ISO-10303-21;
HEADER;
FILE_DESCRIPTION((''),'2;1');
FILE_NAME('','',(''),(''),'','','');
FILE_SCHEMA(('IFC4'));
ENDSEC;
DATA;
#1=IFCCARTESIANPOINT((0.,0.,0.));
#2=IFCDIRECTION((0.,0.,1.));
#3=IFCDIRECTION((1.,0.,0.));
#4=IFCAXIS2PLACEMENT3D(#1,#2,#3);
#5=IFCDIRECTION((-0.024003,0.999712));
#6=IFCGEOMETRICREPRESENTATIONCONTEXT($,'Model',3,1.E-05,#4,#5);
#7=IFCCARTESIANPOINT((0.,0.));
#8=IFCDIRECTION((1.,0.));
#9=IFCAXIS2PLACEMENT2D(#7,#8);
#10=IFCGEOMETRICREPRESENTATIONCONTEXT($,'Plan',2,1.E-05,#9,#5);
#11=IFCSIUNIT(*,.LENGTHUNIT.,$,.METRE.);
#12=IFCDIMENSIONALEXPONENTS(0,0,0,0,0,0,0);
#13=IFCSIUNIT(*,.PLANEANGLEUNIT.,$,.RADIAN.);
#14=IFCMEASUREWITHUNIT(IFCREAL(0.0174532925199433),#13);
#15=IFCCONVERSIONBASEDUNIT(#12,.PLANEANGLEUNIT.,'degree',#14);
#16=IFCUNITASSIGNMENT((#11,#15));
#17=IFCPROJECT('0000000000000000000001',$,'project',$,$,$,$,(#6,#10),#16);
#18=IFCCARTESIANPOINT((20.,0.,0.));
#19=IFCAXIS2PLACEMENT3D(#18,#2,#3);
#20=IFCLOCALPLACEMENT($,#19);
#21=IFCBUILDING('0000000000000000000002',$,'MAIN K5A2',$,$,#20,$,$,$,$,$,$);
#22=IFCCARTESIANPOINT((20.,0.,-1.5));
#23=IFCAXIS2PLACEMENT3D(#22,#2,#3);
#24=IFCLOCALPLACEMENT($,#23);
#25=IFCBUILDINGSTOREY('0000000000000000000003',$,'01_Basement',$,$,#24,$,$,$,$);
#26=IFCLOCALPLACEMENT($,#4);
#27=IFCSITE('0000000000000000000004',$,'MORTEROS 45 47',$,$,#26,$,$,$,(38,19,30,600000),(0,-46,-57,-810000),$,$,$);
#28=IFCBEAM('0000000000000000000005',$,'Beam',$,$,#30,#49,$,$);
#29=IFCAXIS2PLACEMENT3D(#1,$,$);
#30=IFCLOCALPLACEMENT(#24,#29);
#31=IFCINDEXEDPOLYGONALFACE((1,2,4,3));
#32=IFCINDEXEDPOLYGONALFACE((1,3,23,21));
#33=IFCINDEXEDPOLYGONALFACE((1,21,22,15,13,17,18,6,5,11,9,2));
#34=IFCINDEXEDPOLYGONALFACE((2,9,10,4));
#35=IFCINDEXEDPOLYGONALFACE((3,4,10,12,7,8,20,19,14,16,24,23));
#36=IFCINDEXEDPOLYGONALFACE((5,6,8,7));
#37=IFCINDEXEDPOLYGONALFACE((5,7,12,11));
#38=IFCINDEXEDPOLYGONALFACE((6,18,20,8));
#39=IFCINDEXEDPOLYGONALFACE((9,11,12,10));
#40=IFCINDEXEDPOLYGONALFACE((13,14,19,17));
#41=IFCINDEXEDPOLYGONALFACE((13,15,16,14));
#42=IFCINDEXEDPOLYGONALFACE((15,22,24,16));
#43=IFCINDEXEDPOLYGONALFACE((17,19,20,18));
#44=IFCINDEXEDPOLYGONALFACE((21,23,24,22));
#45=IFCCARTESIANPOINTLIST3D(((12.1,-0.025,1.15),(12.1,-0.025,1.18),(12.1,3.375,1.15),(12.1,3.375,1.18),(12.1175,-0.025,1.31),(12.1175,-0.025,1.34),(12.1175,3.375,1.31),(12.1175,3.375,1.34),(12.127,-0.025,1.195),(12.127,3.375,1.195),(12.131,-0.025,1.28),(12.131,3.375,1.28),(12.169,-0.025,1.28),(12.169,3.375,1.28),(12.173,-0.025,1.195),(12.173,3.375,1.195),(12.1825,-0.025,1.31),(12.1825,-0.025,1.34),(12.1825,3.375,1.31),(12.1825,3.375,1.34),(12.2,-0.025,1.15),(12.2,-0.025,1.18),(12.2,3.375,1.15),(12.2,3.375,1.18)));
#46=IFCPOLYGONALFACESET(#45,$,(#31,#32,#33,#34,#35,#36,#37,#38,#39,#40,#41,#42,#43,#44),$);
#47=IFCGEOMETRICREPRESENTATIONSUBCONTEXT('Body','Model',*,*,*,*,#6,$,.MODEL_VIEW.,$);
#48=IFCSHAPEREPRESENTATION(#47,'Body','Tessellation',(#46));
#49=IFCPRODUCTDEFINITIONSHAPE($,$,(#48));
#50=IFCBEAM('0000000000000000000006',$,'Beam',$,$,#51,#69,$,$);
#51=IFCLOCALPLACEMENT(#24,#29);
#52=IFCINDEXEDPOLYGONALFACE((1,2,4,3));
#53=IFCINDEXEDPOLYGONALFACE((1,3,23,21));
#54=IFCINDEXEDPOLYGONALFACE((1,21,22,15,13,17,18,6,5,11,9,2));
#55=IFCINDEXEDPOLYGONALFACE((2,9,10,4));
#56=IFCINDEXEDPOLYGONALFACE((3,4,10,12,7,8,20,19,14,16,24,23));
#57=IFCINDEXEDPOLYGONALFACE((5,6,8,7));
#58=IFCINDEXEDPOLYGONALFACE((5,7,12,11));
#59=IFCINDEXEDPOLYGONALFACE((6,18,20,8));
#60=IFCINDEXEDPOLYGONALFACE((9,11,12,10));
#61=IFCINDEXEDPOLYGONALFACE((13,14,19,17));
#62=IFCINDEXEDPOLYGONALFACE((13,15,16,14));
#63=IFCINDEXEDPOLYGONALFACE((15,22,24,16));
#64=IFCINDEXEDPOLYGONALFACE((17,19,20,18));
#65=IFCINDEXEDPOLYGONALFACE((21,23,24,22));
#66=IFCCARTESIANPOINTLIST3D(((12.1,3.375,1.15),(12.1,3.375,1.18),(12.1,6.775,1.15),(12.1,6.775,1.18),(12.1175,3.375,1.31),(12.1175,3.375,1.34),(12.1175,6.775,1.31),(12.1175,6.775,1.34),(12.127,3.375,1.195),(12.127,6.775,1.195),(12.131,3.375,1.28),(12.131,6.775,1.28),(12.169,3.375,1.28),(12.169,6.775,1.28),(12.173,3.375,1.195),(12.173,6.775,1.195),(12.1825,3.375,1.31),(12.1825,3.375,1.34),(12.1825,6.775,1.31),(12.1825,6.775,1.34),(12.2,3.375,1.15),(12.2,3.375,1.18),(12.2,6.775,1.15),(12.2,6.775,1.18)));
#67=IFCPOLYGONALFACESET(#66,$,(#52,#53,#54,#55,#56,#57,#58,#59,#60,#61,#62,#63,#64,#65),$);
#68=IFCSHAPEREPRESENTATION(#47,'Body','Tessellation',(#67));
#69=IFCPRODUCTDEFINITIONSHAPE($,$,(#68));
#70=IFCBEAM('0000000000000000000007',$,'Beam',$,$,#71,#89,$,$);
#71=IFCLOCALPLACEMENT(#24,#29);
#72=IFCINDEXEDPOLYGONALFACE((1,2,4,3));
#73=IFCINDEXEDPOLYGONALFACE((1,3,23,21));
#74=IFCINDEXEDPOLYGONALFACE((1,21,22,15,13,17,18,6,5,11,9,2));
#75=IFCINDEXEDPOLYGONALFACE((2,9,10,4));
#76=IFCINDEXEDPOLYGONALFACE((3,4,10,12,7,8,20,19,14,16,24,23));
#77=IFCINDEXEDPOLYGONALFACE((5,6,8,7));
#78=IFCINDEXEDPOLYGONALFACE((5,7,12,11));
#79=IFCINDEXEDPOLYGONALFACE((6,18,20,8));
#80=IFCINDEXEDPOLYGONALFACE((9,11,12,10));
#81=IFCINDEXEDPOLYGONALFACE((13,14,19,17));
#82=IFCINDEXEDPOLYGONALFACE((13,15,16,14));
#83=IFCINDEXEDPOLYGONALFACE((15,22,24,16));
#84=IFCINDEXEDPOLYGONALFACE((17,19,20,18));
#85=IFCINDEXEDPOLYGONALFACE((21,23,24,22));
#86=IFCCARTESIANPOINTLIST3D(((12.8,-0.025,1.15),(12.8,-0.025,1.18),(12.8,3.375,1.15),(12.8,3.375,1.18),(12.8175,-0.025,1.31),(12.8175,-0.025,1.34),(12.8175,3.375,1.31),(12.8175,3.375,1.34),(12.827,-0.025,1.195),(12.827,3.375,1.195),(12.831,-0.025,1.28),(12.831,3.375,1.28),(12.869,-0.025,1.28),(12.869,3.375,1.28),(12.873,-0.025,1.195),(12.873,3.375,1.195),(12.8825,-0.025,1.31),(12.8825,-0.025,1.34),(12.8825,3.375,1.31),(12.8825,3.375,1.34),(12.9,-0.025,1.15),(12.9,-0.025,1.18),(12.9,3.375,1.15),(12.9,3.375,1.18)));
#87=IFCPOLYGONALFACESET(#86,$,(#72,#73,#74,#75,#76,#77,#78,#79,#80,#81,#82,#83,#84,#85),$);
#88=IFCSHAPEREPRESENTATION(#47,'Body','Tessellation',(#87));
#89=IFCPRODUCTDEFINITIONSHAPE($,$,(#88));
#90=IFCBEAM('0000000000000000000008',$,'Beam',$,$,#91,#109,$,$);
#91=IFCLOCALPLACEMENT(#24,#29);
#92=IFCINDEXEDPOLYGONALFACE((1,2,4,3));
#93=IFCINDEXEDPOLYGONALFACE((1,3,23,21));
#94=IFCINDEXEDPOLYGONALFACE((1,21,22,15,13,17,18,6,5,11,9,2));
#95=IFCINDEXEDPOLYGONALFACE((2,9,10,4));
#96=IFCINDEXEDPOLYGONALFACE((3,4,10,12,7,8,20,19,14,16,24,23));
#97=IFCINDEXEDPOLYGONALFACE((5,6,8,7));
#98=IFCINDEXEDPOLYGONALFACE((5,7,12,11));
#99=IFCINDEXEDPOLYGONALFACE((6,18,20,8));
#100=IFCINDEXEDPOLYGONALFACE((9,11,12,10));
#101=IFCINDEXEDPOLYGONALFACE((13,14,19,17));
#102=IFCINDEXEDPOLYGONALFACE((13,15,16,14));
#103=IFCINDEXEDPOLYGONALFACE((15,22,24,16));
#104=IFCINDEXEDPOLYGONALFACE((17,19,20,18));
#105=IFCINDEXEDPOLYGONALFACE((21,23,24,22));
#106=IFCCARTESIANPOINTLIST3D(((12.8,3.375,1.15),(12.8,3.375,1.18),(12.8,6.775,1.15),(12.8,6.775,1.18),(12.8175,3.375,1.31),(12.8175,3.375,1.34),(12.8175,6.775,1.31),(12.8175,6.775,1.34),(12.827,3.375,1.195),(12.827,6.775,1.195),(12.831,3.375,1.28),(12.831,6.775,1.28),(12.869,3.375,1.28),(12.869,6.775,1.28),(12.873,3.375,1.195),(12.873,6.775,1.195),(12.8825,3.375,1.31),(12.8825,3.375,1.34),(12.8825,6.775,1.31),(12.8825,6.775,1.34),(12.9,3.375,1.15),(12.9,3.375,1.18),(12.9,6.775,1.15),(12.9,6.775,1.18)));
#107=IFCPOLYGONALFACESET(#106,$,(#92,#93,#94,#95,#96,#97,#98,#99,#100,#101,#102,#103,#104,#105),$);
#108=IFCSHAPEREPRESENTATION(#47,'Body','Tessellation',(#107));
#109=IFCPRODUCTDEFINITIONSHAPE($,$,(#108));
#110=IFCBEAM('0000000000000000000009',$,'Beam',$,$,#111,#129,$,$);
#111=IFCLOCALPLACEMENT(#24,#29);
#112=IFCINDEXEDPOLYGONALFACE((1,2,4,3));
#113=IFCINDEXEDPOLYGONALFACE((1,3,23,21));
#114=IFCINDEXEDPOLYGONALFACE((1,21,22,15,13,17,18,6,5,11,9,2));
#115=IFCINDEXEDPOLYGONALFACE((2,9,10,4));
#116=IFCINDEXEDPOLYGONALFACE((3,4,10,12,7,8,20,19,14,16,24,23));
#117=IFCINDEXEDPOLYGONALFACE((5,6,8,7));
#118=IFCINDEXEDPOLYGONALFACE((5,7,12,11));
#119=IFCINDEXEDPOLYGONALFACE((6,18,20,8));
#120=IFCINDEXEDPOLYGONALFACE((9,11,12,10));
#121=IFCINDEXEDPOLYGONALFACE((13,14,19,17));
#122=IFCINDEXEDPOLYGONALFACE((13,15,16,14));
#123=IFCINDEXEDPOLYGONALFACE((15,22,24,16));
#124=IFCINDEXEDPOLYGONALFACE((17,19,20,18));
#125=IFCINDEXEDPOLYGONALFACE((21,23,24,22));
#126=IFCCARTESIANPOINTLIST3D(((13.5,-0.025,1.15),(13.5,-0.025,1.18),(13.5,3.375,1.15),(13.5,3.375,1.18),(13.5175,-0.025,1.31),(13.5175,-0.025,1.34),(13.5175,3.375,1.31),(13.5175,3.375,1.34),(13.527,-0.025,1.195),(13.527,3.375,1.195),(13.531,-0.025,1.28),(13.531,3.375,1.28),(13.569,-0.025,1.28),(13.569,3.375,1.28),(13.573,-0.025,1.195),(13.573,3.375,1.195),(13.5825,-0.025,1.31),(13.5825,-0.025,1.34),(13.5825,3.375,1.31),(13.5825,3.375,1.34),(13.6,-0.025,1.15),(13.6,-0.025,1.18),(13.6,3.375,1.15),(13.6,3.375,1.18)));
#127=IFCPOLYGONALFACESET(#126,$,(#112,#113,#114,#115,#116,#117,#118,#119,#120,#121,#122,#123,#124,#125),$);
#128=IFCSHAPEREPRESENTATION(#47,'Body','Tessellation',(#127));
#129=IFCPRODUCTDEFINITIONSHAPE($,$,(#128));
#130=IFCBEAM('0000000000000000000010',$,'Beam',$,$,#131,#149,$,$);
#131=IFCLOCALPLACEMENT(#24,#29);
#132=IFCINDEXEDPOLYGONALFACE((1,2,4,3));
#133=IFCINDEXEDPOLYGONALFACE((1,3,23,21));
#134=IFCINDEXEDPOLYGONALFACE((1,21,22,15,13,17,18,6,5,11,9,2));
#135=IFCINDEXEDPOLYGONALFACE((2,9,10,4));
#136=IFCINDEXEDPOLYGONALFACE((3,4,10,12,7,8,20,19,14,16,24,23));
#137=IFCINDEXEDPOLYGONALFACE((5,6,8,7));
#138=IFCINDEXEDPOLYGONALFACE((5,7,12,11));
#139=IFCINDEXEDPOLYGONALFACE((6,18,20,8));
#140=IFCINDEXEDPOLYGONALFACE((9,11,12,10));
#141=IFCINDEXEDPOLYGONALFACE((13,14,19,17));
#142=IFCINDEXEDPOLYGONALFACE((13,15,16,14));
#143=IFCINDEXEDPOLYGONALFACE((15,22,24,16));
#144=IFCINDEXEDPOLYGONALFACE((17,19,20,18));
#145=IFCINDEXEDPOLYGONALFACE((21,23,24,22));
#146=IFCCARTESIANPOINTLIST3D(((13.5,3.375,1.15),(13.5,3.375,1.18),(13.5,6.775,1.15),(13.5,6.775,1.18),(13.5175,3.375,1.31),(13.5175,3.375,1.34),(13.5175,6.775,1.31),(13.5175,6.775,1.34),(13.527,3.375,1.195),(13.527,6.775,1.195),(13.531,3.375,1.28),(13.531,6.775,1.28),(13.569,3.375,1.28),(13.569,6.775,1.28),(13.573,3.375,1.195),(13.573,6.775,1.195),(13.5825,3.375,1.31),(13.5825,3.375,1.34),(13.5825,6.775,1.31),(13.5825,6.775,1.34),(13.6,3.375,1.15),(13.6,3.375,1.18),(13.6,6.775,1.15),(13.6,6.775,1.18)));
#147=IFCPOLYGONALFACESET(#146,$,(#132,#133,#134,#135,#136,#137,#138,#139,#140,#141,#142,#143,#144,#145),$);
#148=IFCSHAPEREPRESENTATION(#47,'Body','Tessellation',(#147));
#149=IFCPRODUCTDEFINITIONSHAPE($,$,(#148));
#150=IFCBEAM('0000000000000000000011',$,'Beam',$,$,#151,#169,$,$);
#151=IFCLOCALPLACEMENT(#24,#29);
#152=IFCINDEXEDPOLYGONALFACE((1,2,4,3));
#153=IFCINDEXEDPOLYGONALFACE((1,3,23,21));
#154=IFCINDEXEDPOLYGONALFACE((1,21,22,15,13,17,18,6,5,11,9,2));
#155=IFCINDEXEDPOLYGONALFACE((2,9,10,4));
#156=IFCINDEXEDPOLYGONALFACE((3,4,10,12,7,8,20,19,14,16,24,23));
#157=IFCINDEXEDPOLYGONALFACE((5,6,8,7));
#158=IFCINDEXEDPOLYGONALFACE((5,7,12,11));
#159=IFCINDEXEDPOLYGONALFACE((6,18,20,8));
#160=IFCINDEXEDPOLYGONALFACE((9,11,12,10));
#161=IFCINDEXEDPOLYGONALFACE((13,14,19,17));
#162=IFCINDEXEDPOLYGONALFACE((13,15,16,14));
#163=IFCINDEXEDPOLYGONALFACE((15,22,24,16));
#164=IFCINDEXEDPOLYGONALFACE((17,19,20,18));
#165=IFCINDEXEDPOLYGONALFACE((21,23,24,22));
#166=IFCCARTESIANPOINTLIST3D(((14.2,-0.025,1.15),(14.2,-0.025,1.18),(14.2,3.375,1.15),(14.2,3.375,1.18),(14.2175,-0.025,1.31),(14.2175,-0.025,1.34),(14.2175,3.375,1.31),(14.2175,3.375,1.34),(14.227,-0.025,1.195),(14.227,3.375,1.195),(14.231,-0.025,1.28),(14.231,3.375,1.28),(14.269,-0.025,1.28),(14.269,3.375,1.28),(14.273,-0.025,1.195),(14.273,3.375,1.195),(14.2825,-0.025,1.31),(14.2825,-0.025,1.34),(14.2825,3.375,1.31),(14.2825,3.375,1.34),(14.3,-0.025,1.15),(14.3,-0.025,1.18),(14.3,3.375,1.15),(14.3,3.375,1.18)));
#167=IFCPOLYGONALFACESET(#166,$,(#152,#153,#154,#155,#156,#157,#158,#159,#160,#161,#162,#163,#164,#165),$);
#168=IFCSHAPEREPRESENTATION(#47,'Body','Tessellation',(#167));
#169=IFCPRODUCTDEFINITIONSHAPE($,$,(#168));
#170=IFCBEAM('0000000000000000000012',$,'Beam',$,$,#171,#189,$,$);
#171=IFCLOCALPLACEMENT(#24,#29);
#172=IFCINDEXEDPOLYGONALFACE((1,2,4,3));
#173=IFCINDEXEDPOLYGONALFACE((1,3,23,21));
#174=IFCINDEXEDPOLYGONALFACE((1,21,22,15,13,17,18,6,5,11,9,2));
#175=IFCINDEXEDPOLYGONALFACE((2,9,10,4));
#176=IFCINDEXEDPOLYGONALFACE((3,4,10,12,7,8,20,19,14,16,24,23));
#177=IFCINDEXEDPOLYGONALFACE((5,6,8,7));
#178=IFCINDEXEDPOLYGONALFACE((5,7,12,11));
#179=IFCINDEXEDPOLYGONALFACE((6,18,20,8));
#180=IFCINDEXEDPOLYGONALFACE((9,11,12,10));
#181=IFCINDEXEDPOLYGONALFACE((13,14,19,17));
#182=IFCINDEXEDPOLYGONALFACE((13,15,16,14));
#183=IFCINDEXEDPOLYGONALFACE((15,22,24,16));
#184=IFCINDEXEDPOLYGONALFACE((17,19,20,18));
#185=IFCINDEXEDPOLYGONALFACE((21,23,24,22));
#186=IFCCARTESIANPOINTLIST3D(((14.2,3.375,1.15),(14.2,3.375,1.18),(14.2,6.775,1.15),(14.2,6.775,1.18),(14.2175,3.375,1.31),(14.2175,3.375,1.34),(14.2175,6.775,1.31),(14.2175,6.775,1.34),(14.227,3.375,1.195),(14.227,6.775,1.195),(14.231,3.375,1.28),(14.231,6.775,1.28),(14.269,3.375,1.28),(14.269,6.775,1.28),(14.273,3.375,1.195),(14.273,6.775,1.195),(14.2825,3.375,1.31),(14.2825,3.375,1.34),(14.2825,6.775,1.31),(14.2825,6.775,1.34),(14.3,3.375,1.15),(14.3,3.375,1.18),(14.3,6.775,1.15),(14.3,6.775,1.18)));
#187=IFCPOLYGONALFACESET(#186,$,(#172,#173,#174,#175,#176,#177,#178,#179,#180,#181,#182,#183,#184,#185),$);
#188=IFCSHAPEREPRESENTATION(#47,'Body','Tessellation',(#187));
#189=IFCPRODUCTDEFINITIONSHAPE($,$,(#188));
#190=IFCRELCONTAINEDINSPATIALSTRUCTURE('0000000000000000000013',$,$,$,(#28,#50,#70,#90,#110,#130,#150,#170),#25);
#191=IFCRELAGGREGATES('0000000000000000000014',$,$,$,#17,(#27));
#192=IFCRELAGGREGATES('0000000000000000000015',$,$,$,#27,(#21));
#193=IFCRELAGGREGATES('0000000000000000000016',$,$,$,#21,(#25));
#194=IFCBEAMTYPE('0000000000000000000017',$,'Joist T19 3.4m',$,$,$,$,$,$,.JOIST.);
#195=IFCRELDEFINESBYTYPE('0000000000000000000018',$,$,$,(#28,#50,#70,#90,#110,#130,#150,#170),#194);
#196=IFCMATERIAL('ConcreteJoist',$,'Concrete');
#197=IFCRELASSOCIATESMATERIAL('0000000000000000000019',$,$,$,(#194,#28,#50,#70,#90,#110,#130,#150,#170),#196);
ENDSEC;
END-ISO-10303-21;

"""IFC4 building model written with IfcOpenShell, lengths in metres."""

from ifc_helpers import new_model, entity, si_unit, converted_unit, direction, frame, origin_with_axes, origin_2d_with_axis, place, context, subcontext, project, spatial, indexed_curve, outline, extrude, material, material_profile, profile_set, profile_usage, type_object, element, save


model = new_model("IFC4")

# Units and contexts
model_context = context("Model", 3, precision=1e-05, world=origin_with_axes(), true_north=direction((-0.024003, 0.999712)))
plan_context = context("Plan", 2, precision=1e-05, world=origin_2d_with_axis(), true_north=direction((-0.024003, 0.999712)))
body_context = subcontext(model_context, "Body", "Model", "MODEL_VIEW")
ifc_project = project(units=[si_unit("LENGTHUNIT", "METRE"), converted_unit("PLANEANGLEUNIT", "degree", entity("IfcReal", 0.0174532925199433), si_unit("PLANEANGLEUNIT", "RADIAN"), dimensions=[0, 0, 0, 0, 0, 0, 0])], contexts=[model_context, plan_context])

# Site, building, storey
site_placement = place(None, origin_with_axes())
site = spatial("IfcSite", under=ifc_project, at=site_placement, Name="MORTEROS 45 47", RefLatitude=(38, 19, 30, 600000), RefLongitude=(0, -46, -57, -810000))
building_placement = place(None, frame((20.0, 0.0, 0.0), z_axis=(0.0, 0.0, 1.0), x_axis=(1.0, 0.0, 0.0)))
building = spatial("IfcBuilding", under=site, at=building_placement, Name="MAIN K5A2")
storey_placement = place(None, frame((20.0, 0.0, -1.5), z_axis=(0.0, 0.0, 1.0), x_axis=(1.0, 0.0, 0.0)))
storey = spatial("IfcBuildingStorey", under=building, at=storey_placement, Name="01_Basement")

# Beams
ifc_material = material(Name="ConcreteJoist", Category="Concrete")
ifc_material_profile = material_profile(ifc_material, outline(indexed_curve([(0.019, 0.13), (0.023, 0.045), (0.05, 0.03), (0.05, 0.0), (-0.05, 0.0), (-0.05, 0.03), (-0.023, 0.045), (-0.019, 0.13), (-0.0325, 0.16), (-0.0325, 0.19), (0.0325, 0.19), (0.0325, 0.16), (0.019, 0.13)])))
ifc_profile_set = profile_set([ifc_material_profile], Name="JoistMaterialProfileSet")
ifc_profile_usage_1 = profile_usage(ifc_profile_set, cardinal=5)
beam_type = type_object("IfcBeamType", Name="Joist T19 3.4m", PredefinedType="JOIST", material=ifc_profile_set)
beam_1_placement = place(None, frame((32.15, -0.025, -0.35), z_axis=(0.0, 1.0, 0.0), x_axis=(-1.0, 0.0, 0.0)))
element("IfcBeam", 1, at=beam_1_placement, inside=storey, type_object=beam_type, material=ifc_profile_usage_1, Name="Beam", context=body_context, shape_type="SweptSolid", body=[
    extrude(outline(indexed_curve([(0.019, 0.13), (0.023, 0.045), (0.05, 0.03), (0.05, 0.0), (-0.05, 0.0), (-0.05, 0.03), (-0.023, 0.045), (-0.019, 0.13), (-0.0325, 0.16), (-0.0325, 0.19), (0.0325, 0.19), (0.0325, 0.16), (0.019, 0.13)])), origin_with_axes(), (0.0, 0.0, 1.0), 3.4),
])
ifc_profile_usage_2 = profile_usage(ifc_profile_set, cardinal=5)
beam_2_placement = place(None, frame((32.15, 3.375, -0.35), z_axis=(0.0, 1.0, 0.0), x_axis=(-1.0, 0.0, 0.0)))
element("IfcBeam", 2, at=beam_2_placement, inside=storey, type_object=beam_type, material=ifc_profile_usage_2, Name="Beam", context=body_context, shape_type="SweptSolid", body=[
    extrude(outline(indexed_curve([(0.019, 0.13), (0.023, 0.045), (0.05, 0.03), (0.05, 0.0), (-0.05, 0.0), (-0.05, 0.03), (-0.023, 0.045), (-0.019, 0.13), (-0.0325, 0.16), (-0.0325, 0.19), (0.0325, 0.19), (0.0325, 0.16), (0.019, 0.13)])), origin_with_axes(), (0.0, 0.0, 1.0), 3.4),
])
ifc_profile_usage_3 = profile_usage(ifc_profile_set, cardinal=5)
beam_3_placement = place(None, frame((32.85, -0.025, -0.35), z_axis=(0.0, 1.0, 0.0), x_axis=(-1.0, 0.0, 0.0)))
element("IfcBeam", 3, at=beam_3_placement, inside=storey, type_object=beam_type, material=ifc_profile_usage_3, Name="Beam", context=body_context, shape_type="SweptSolid", body=[
    extrude(outline(indexed_curve([(0.019, 0.13), (0.023, 0.045), (0.05, 0.03), (0.05, 0.0), (-0.05, 0.0), (-0.05, 0.03), (-0.023, 0.045), (-0.019, 0.13), (-0.0325, 0.16), (-0.0325, 0.19), (0.0325, 0.19), (0.0325, 0.16), (0.019, 0.13)])), origin_with_axes(), (0.0, 0.0, 1.0), 3.4),
])
ifc_profile_usage_4 = profile_usage(ifc_profile_set, cardinal=5)
beam_4_placement = place(None, frame((32.85, 3.375, -0.35), z_axis=(0.0, 1.0, 0.0), x_axis=(-1.0, 0.0, 0.0)))
element("IfcBeam", 4, at=beam_4_placement, inside=storey, type_object=beam_type, material=ifc_profile_usage_4, Name="Beam", context=body_context, shape_type="SweptSolid", body=[
    extrude(outline(indexed_curve([(0.019, 0.13), (0.023, 0.045), (0.05, 0.03), (0.05, 0.0), (-0.05, 0.0), (-0.05, 0.03), (-0.023, 0.045), (-0.019, 0.13), (-0.0325, 0.16), (-0.0325, 0.19), (0.0325, 0.19), (0.0325, 0.16), (0.019, 0.13)])), origin_with_axes(), (0.0, 0.0, 1.0), 3.4),
])
ifc_profile_usage_5 = profile_usage(ifc_profile_set, cardinal=5)
beam_5_placement = place(None, frame((33.55, -0.025, -0.35), z_axis=(0.0, 1.0, 0.0), x_axis=(-1.0, 0.0, 0.0)))
element("IfcBeam", 5, at=beam_5_placement, inside=storey, type_object=beam_type, material=ifc_profile_usage_5, Name="Beam", context=body_context, shape_type="SweptSolid", body=[
    extrude(outline(indexed_curve([(0.019, 0.13), (0.023, 0.045), (0.05, 0.03), (0.05, 0.0), (-0.05, 0.0), (-0.05, 0.03), (-0.023, 0.045), (-0.019, 0.13), (-0.0325, 0.16), (-0.0325, 0.19), (0.0325, 0.19), (0.0325, 0.16), (0.019, 0.13)])), origin_with_axes(), (0.0, 0.0, 1.0), 3.4),
])
ifc_profile_usage_6 = profile_usage(ifc_profile_set, cardinal=5)
beam_6_placement = place(None, frame((33.55, 3.375, -0.35), z_axis=(0.0, 1.0, 0.0), x_axis=(-1.0, 0.0, 0.0)))
element("IfcBeam", 6, at=beam_6_placement, inside=storey, type_object=beam_type, material=ifc_profile_usage_6, Name="Beam", context=body_context, shape_type="SweptSolid", body=[
    extrude(outline(indexed_curve([(0.019, 0.13), (0.023, 0.045), (0.05, 0.03), (0.05, 0.0), (-0.05, 0.0), (-0.05, 0.03), (-0.023, 0.045), (-0.019, 0.13), (-0.0325, 0.16), (-0.0325, 0.19), (0.0325, 0.19), (0.0325, 0.16), (0.019, 0.13)])), origin_with_axes(), (0.0, 0.0, 1.0), 3.4),
])
ifc_profile_usage_7 = profile_usage(ifc_profile_set, cardinal=5)
beam_7_placement = place(None, frame((34.25, -0.025, -0.35), z_axis=(0.0, 1.0, 0.0), x_axis=(-1.0, 0.0, 0.0)))
element("IfcBeam", 7, at=beam_7_placement, inside=storey, type_object=beam_type, material=ifc_profile_usage_7, Name="Beam", context=body_context, shape_type="SweptSolid", body=[
    extrude(outline(indexed_curve([(0.019, 0.13), (0.023, 0.045), (0.05, 0.03), (0.05, 0.0), (-0.05, 0.0), (-0.05, 0.03), (-0.023, 0.045), (-0.019, 0.13), (-0.0325, 0.16), (-0.0325, 0.19), (0.0325, 0.19), (0.0325, 0.16), (0.019, 0.13)])), origin_with_axes(), (0.0, 0.0, 1.0), 3.4),
])
ifc_profile_usage_8 = profile_usage(ifc_profile_set, cardinal=5)
beam_8_placement = place(None, frame((34.25, 3.375, -0.35), z_axis=(0.0, 1.0, 0.0), x_axis=(-1.0, 0.0, 0.0)))
element("IfcBeam", 8, at=beam_8_placement, inside=storey, type_object=beam_type, material=ifc_profile_usage_8, Name="Beam", context=body_context, shape_type="SweptSolid", body=[
    extrude(outline(indexed_curve([(0.019, 0.13), (0.023, 0.045), (0.05, 0.03), (0.05, 0.0), (-0.05, 0.0), (-0.05, 0.03), (-0.023, 0.045), (-0.019, 0.13), (-0.0325, 0.16), (-0.0325, 0.19), (0.0325, 0.19), (0.0325, 0.16), (0.019, 0.13)])), origin_with_axes(), (0.0, 0.0, 1.0), 3.4),
])

save(model, "model.ifc")
